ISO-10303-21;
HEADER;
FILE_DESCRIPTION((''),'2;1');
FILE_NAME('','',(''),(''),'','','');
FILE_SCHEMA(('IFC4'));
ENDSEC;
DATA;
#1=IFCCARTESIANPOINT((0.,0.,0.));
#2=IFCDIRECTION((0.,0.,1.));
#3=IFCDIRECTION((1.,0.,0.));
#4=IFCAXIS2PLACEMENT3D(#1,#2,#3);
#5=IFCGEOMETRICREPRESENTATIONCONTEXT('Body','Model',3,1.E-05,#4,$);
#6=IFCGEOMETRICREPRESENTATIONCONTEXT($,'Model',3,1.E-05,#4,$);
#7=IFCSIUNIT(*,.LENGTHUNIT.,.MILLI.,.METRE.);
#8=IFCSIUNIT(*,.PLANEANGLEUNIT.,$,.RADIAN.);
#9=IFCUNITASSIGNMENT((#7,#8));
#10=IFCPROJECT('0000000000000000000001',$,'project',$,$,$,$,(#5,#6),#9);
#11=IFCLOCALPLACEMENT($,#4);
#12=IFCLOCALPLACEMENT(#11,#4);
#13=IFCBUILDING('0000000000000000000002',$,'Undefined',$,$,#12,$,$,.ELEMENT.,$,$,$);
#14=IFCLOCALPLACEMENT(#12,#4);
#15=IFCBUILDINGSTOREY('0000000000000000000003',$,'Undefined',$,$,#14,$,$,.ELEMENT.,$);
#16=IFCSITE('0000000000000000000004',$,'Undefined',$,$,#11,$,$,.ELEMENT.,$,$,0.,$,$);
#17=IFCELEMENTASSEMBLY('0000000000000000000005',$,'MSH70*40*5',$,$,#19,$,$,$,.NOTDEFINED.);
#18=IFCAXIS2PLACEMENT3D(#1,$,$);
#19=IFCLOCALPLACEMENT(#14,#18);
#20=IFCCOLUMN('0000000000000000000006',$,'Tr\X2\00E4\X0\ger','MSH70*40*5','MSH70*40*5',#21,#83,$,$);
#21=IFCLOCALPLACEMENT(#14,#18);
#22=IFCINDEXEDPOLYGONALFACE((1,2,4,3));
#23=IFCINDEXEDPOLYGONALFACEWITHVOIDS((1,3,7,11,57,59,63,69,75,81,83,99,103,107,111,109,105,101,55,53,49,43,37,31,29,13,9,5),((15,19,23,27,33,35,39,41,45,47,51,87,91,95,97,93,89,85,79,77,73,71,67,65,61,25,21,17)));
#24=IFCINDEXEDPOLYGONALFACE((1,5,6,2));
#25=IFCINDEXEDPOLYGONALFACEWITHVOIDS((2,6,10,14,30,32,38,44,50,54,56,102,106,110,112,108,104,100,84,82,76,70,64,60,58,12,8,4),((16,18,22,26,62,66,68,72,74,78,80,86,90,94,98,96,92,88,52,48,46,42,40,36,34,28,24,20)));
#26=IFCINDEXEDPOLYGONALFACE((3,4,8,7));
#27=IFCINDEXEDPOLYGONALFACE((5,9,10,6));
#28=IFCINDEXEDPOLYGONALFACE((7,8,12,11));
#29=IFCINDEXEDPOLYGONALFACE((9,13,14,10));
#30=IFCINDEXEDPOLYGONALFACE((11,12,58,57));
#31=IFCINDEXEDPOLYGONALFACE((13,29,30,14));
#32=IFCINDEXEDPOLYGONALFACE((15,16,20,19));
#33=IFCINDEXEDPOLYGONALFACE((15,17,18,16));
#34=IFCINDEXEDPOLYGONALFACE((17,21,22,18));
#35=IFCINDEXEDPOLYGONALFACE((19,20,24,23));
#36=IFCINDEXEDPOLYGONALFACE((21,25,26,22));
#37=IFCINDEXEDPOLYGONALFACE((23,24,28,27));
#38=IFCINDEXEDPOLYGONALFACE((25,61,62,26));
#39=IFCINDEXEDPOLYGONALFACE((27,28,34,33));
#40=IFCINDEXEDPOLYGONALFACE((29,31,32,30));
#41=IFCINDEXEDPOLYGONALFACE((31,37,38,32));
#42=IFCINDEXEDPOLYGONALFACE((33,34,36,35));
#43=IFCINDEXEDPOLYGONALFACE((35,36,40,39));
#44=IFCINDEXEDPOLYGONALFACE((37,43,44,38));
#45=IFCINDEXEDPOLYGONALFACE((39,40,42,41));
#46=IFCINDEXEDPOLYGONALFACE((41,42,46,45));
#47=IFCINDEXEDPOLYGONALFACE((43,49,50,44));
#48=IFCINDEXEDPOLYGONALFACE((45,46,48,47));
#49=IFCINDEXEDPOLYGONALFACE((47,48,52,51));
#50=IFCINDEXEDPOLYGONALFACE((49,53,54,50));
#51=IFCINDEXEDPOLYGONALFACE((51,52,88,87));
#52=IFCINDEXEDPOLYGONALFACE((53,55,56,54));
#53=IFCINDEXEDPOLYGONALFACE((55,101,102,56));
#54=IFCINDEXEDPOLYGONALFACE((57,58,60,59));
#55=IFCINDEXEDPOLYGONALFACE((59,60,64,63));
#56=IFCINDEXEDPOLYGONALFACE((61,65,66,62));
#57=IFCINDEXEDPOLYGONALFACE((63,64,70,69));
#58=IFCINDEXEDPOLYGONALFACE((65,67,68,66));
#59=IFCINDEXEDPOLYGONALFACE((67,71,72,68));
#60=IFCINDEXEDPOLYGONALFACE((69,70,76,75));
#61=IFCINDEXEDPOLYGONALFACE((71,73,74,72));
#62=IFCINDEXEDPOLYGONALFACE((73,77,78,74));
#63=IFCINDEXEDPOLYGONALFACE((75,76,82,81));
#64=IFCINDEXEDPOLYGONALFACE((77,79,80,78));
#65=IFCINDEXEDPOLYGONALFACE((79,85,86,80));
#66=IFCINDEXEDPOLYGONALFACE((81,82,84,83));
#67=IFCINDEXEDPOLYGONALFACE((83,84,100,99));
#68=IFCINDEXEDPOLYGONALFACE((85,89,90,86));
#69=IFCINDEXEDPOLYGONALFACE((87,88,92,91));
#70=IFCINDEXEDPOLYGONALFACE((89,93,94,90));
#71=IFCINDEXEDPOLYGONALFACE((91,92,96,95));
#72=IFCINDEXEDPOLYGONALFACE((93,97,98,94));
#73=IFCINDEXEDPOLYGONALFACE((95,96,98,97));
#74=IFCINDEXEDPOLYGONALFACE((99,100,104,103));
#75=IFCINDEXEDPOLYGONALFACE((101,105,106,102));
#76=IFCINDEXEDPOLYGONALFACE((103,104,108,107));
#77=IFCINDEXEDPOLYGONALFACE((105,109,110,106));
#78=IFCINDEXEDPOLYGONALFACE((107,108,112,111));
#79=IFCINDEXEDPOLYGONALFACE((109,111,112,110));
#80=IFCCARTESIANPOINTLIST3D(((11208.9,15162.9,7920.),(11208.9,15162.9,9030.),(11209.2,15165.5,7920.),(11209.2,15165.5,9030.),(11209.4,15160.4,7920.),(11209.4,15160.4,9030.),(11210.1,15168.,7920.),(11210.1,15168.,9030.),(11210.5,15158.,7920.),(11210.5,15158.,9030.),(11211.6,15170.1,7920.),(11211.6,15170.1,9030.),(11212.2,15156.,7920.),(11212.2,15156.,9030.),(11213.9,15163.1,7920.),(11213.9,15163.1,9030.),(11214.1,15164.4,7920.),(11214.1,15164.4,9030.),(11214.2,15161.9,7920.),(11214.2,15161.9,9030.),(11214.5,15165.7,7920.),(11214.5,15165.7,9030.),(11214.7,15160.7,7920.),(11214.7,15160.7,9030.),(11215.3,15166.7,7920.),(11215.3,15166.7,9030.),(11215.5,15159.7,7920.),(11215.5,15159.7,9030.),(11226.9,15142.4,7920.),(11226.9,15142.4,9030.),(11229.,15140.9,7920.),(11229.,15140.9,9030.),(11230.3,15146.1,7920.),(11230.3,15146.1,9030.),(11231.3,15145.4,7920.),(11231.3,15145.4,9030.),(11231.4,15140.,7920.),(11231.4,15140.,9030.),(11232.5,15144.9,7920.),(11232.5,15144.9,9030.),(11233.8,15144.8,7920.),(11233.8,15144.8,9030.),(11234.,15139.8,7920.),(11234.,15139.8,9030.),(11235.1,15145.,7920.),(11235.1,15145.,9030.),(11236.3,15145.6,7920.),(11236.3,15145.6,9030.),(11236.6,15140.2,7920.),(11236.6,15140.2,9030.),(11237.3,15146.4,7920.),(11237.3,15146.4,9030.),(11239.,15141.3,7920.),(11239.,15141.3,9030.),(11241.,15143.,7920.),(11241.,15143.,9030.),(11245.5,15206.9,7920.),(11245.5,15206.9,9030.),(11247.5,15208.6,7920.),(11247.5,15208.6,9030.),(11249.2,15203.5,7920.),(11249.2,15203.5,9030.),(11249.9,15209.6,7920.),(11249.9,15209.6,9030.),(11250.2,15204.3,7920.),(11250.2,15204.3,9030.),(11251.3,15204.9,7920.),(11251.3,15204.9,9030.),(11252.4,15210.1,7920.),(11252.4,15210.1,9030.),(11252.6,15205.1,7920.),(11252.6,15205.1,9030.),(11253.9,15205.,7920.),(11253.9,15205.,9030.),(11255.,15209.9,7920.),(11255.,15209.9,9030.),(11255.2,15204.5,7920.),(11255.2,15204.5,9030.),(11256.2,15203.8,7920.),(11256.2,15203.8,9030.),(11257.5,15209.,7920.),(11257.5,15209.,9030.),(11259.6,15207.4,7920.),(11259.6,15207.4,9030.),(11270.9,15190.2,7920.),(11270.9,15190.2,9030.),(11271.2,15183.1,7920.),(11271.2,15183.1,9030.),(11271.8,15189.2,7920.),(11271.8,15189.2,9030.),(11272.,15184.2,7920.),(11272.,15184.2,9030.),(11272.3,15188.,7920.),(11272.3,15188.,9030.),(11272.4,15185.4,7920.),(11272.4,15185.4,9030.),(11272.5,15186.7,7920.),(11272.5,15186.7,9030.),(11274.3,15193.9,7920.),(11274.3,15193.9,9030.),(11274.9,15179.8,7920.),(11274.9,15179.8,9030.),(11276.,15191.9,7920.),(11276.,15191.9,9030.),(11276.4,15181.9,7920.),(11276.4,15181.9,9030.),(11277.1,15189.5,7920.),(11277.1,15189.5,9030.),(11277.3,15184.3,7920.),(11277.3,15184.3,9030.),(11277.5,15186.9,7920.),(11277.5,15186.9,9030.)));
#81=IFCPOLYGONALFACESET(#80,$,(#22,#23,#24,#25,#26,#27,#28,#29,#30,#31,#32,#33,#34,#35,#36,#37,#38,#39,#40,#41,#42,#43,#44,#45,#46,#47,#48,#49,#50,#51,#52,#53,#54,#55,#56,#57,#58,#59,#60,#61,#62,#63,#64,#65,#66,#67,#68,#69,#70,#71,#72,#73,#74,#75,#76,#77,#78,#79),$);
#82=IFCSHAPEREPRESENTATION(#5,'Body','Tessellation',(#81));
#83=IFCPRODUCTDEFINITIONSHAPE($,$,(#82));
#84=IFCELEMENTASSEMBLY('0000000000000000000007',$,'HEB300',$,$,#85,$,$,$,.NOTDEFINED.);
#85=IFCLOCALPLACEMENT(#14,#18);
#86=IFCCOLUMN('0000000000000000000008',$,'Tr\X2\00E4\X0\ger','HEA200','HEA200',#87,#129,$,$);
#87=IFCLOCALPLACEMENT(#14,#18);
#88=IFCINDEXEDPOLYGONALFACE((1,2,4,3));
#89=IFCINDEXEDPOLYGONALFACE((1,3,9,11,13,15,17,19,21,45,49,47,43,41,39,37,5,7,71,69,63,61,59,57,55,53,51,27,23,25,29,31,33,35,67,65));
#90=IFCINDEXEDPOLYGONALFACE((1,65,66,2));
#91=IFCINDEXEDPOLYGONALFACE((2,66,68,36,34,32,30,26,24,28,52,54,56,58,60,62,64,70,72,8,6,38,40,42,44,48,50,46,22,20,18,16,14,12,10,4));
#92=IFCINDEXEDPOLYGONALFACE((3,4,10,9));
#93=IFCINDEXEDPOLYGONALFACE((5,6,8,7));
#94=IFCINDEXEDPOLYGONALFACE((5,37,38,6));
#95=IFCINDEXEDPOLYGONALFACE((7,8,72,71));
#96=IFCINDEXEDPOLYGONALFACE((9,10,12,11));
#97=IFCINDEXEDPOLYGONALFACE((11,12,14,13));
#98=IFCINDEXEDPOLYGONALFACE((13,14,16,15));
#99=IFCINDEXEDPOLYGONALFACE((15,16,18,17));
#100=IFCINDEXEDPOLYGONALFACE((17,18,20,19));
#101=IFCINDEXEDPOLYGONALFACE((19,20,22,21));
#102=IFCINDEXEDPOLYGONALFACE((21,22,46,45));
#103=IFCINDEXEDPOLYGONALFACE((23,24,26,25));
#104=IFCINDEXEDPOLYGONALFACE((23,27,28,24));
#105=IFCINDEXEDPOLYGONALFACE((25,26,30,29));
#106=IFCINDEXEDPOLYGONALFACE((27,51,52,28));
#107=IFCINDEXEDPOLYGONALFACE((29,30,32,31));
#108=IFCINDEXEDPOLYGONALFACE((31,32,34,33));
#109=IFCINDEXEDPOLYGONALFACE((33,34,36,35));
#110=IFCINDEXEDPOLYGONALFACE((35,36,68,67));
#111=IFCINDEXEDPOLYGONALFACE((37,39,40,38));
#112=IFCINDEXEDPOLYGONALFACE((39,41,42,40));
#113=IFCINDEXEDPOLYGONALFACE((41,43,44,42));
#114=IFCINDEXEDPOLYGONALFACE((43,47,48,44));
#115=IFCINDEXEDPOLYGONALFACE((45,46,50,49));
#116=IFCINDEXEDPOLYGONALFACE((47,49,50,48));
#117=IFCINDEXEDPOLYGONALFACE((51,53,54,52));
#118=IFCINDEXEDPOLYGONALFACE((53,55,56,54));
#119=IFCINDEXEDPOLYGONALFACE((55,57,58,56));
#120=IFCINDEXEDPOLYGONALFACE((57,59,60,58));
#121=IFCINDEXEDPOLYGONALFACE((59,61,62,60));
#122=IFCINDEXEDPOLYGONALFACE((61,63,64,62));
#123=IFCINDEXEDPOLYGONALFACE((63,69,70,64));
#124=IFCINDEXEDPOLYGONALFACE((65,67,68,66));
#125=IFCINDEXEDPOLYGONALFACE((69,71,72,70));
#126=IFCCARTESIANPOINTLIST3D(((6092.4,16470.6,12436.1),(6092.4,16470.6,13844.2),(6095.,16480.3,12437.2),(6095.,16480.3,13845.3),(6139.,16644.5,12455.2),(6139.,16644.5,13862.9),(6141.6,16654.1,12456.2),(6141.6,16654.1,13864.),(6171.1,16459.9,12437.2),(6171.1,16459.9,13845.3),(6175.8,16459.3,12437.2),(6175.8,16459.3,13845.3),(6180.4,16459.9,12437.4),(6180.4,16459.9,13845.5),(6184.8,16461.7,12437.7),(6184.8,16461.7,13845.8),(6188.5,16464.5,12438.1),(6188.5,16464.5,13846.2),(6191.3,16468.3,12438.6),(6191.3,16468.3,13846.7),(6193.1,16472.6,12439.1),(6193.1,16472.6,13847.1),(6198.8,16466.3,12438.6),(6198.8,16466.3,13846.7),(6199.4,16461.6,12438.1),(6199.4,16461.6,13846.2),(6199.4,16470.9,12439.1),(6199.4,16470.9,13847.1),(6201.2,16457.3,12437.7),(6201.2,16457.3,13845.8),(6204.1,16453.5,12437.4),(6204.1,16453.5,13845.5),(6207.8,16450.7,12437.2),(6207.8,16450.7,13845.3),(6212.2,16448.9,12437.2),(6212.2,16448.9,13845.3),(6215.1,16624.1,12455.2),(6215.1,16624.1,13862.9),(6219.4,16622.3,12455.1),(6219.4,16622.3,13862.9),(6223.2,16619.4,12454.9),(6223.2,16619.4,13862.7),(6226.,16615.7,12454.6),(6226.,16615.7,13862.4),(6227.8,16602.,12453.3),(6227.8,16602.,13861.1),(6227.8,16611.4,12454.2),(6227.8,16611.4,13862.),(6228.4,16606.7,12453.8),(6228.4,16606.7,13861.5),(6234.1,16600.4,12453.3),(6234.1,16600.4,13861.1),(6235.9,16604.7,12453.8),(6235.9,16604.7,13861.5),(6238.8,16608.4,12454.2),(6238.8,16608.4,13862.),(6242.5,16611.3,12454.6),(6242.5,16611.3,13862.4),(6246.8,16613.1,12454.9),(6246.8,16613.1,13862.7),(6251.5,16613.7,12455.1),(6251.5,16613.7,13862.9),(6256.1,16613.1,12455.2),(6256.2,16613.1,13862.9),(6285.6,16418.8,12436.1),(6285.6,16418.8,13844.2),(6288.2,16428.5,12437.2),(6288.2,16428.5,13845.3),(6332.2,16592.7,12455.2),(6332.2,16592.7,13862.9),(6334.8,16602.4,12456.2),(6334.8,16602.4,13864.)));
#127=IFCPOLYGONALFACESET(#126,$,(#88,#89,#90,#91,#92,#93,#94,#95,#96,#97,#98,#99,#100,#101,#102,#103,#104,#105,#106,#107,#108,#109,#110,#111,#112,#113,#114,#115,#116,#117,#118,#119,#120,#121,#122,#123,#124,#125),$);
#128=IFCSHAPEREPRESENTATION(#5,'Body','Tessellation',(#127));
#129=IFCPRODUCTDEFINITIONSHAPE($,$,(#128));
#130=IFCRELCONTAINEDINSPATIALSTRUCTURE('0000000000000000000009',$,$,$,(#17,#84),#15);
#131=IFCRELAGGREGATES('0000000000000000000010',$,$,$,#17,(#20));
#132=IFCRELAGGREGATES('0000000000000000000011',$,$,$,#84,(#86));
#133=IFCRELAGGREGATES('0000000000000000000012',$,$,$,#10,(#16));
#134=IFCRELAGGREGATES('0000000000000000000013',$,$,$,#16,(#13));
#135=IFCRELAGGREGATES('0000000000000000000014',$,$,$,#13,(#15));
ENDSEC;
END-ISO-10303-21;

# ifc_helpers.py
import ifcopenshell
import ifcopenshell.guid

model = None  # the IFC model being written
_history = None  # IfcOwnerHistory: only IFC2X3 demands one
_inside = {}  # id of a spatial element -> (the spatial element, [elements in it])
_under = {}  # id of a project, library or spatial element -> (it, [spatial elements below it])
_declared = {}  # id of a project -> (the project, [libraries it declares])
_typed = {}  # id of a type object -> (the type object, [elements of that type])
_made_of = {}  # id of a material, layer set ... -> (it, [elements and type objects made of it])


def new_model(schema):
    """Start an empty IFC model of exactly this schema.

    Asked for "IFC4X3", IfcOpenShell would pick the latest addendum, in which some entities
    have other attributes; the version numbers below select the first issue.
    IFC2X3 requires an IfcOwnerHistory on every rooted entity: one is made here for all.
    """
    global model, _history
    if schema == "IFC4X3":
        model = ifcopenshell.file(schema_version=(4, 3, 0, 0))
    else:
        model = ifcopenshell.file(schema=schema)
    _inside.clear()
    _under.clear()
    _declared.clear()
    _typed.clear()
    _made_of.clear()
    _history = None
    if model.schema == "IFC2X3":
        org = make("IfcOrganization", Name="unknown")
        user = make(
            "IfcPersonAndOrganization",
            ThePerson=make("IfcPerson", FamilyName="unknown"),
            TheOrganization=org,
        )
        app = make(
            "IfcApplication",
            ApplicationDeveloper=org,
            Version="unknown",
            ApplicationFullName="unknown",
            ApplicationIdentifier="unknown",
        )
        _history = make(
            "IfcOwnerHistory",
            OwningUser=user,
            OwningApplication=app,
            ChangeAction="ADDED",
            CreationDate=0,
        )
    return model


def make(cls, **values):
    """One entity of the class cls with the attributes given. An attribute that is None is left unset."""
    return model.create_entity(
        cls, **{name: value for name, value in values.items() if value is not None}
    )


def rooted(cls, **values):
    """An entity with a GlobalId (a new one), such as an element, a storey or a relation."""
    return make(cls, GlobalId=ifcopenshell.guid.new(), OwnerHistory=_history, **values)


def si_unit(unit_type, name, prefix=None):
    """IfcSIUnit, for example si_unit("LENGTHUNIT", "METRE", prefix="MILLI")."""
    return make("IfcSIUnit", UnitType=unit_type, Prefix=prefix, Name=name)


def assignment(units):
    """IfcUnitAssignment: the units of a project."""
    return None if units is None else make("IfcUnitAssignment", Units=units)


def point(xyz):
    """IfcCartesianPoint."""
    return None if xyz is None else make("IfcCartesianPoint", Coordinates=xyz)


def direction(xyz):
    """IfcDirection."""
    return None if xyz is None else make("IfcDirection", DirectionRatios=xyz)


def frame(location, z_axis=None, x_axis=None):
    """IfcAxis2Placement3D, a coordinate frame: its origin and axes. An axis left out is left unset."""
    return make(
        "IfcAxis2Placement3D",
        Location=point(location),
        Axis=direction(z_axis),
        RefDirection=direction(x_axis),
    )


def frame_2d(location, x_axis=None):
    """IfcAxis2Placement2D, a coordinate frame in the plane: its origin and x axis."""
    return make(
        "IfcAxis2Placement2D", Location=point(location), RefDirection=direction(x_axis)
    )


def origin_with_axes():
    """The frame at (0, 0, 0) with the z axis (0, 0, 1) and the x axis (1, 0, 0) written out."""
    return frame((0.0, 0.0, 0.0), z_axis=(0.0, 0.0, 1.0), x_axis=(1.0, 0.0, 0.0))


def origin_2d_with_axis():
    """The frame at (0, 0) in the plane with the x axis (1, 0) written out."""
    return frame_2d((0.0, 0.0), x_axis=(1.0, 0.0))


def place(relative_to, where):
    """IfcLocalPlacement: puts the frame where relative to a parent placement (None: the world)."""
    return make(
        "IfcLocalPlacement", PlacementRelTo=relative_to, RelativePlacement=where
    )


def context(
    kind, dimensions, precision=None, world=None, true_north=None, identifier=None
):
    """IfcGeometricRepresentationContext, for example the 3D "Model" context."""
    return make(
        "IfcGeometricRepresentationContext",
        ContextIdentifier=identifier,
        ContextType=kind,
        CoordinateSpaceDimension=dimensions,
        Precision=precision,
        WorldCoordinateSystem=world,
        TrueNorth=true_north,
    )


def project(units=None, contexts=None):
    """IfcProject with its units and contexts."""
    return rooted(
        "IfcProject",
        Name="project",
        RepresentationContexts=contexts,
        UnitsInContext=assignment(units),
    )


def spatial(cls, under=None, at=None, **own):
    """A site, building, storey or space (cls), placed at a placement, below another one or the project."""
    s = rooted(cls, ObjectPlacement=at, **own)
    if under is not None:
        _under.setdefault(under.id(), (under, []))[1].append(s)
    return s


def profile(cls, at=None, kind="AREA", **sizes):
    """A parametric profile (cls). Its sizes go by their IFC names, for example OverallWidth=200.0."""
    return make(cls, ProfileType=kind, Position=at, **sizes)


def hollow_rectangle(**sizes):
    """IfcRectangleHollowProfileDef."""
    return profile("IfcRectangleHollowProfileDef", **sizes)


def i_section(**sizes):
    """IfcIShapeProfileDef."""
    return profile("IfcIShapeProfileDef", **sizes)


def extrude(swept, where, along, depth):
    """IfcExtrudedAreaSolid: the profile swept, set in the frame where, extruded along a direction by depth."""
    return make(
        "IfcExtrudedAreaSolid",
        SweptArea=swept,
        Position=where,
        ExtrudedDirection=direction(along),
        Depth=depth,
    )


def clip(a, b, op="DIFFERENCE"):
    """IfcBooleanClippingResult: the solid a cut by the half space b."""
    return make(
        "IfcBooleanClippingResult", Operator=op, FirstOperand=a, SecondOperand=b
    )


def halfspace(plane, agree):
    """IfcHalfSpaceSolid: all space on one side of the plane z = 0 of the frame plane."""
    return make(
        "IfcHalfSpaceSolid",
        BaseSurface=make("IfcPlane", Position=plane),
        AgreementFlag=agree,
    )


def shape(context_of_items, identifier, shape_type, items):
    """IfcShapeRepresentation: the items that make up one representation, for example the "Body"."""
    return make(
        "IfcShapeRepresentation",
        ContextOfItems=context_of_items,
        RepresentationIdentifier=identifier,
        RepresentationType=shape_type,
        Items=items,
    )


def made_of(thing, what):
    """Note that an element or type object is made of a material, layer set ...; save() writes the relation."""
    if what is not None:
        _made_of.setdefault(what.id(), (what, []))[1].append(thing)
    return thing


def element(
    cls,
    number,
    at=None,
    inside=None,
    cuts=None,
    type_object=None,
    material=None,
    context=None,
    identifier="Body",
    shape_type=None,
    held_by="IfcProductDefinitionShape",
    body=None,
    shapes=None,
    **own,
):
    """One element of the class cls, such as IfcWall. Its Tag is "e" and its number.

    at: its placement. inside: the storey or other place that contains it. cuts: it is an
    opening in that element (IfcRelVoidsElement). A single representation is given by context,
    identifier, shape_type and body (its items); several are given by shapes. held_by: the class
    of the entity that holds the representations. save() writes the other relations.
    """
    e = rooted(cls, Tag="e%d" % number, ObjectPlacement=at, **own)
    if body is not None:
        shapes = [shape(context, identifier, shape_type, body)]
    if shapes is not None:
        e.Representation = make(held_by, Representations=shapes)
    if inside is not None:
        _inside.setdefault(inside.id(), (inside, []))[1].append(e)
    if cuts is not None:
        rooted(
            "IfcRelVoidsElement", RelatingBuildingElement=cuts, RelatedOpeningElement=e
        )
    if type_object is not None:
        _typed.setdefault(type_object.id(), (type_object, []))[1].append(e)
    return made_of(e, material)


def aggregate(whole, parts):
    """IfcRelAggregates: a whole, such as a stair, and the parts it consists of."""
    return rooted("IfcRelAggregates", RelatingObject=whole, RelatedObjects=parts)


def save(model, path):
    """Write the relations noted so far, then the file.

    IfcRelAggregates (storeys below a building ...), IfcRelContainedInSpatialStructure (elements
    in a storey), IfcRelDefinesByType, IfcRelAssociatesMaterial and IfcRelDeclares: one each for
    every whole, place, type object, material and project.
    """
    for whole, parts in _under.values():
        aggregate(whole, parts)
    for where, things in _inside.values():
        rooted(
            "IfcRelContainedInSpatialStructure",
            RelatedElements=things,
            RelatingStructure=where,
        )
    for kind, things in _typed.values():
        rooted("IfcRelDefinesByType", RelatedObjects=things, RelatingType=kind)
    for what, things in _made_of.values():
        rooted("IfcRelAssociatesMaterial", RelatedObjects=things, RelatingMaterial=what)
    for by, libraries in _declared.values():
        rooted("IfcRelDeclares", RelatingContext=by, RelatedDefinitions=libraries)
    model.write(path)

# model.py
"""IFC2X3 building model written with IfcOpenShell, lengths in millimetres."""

from ifc_helpers import new_model, si_unit, frame, origin_with_axes, origin_2d_with_axis, place, context, project, spatial, hollow_rectangle, i_section, extrude, clip, halfspace, element, aggregate, save


model = new_model("IFC2X3")

# Units and contexts
model_context_1 = context("Model", 3, precision=1e-05, world=origin_with_axes(), identifier="Body")
model_context_2 = context("Model", 3, precision=1e-05, world=origin_with_axes())
ifc_project = project(units=[si_unit("LENGTHUNIT", "METRE", prefix="MILLI"), si_unit("PLANEANGLEUNIT", "RADIAN")], contexts=[model_context_1, model_context_2])

# Site, building, storey
site_placement = place(None, origin_with_axes())
site = spatial("IfcSite", under=ifc_project, at=site_placement, Name="Undefined", CompositionType="ELEMENT", RefElevation=0.0)
building_placement = place(site_placement, origin_with_axes())
building = spatial("IfcBuilding", under=site, at=building_placement, Name="Undefined", CompositionType="ELEMENT")
storey_placement = place(building_placement, origin_with_axes())
storey = spatial("IfcBuildingStorey", under=building, at=storey_placement, Name="Undefined", CompositionType="ELEMENT")

# Element assembly
assembly_1 = element("IfcElementAssembly", 1, inside=storey, Name="MSH70*40*5", PredefinedType="NOTDEFINED")

# Column
column_1_placement = place(storey_placement, frame((11243.2, 15174.9, 7920.0), z_axis=(0.0, 0.0, 1.0), x_axis=(1.0, 0.0, 0.0)))
column_1 = element("IfcColumn", 2, at=column_1_placement, Name="Träger", Description="MSH70*40*5", ObjectType="MSH70*40*5", context=model_context_1, shape_type="SweptSolid", body=[
    extrude(hollow_rectangle(XDim=40.0, YDim=70.0, WallThickness=5.0, InnerFilletRadius=5.0, OuterFilletRadius=10.0, at=origin_2d_with_axis()), frame((0.0, 0.0, 1110.0), z_axis=(0.0, 0.0, -1.0), x_axis=(-0.735082, 0.677978, 0.000005)), (0.0, 0.0, 1.0), 1110.0),
])
aggregate(assembly_1, [column_1])

# Element assembly, column
assembly_2 = element("IfcElementAssembly", 3, inside=storey, Name="HEB300", PredefinedType="NOTDEFINED")
column_2_placement = place(storey_placement, frame((6213.6, 16536.5, 12295.6), z_axis=(0.0, 0.0, 1.0), x_axis=(1.0, 0.0, 0.0)))
column_2 = element("IfcColumn", 4, at=column_2_placement, Name="Träger", Description="HEA200", ObjectType="HEA200", context=model_context_1, shape_type="Clipping", body=[
    clip(clip(extrude(i_section(OverallWidth=200.0, OverallDepth=190.0, WebThickness=6.5, FlangeThickness=10.0, FilletRadius=18.0, at=origin_2d_with_axis()), frame((0.0, 0.0, 1578.6), z_axis=(0.0, 0.0, -1.0), x_axis=(-0.965926, 0.258819, 0.0)), (0.0, 0.0, 1.0), 1448.2), halfspace(frame((-24.6, -91.8, 1548.6), z_axis=(0.026748, 0.099826, -0.994645), x_axis=(0.965926, -0.258819, 0.0)), True)), halfspace(frame((0.0, 0.0, 150.6), z_axis=(0.027262, 0.101742, -0.994437), x_axis=(0.965926, -0.258819, 0.0)), False)),
])
aggregate(assembly_2, [column_2])

save(model, "model.ifc")
